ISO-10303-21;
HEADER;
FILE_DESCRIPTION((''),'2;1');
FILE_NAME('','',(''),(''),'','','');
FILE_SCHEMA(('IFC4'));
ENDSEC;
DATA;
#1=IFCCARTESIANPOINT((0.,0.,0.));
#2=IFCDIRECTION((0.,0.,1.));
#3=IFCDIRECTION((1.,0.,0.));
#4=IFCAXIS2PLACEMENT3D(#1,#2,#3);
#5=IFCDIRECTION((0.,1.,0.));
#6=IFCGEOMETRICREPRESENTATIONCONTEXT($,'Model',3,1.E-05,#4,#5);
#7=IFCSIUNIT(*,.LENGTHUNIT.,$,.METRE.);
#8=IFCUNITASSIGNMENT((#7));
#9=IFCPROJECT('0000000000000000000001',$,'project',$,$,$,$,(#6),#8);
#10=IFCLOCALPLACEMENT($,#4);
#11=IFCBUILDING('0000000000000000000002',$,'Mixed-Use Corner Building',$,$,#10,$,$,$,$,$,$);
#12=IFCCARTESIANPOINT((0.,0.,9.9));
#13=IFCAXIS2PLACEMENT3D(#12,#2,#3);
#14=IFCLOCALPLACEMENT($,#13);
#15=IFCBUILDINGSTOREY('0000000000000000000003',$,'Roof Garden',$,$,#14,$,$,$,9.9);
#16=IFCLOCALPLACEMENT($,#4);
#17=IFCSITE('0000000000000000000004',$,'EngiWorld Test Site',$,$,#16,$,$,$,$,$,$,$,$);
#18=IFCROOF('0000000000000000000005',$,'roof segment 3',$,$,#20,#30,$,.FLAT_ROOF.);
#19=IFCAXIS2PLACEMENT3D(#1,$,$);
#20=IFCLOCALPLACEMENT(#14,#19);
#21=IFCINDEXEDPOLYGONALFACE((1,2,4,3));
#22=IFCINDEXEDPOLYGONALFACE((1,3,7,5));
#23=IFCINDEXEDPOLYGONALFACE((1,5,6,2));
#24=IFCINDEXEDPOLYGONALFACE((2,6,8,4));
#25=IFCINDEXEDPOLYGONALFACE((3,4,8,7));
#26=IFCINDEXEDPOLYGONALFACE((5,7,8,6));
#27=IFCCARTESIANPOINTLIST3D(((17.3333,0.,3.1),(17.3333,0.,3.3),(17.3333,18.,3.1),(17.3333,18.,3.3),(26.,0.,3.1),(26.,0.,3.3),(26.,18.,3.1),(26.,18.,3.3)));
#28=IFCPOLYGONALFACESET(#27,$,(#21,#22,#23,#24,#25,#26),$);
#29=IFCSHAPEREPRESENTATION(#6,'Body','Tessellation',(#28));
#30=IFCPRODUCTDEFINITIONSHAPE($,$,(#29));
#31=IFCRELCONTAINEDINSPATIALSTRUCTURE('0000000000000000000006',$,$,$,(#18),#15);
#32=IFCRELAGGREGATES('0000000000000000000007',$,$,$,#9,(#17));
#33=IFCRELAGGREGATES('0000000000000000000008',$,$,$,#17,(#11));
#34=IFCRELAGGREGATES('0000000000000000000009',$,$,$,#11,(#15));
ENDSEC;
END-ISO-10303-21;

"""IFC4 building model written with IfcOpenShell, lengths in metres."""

from ifc_helpers import new_model, si_unit, direction, frame, origin_with_axes, origin_2d_with_axis, place, context, project, spatial, rectangle, extrude, element, save


model = new_model("IFC4")

# Units and contexts
model_context = context("Model", 3, precision=1e-05, world=origin_with_axes(), true_north=direction((0.0, 1.0, 0.0)))
ifc_project = project(units=[si_unit("LENGTHUNIT", "METRE")], contexts=[model_context])

# Site, building, storey
site_placement = place(None, origin_with_axes())
site = spatial("IfcSite", under=ifc_project, at=site_placement, Name="EngiWorld Test Site")
building_placement = place(None, origin_with_axes())
building = spatial("IfcBuilding", under=site, at=building_placement, Name="Mixed-Use Corner Building")
storey_placement = place(None, frame((0.0, 0.0, 9.9), z_axis=(0.0, 0.0, 1.0), x_axis=(1.0, 0.0, 0.0)))
storey = spatial("IfcBuildingStorey", under=building, at=storey_placement, Name="Roof Garden", Elevation=9.9)

# Roof
for number, where, z_axis, x_axis, name in (
    (1, (21.6667, 9.0, 13.0), (0.0, 0.0, 1.0), (1.0, 0.0, 0.0), "roof segment 3"),
):
    element("IfcRoof", number, at=place(None, frame(where, z_axis=z_axis, x_axis=x_axis)), inside=storey, Name=name, PredefinedType="FLAT_ROOF", context=model_context, shape_type="SweptSolid", body=[
        extrude(rectangle(XDim=8.6667, YDim=18.0, at=origin_2d_with_axis()), origin_with_axes(), (0.0, 0.0, 1.0), 0.2),
    ])

save(model, "model.ifc")
